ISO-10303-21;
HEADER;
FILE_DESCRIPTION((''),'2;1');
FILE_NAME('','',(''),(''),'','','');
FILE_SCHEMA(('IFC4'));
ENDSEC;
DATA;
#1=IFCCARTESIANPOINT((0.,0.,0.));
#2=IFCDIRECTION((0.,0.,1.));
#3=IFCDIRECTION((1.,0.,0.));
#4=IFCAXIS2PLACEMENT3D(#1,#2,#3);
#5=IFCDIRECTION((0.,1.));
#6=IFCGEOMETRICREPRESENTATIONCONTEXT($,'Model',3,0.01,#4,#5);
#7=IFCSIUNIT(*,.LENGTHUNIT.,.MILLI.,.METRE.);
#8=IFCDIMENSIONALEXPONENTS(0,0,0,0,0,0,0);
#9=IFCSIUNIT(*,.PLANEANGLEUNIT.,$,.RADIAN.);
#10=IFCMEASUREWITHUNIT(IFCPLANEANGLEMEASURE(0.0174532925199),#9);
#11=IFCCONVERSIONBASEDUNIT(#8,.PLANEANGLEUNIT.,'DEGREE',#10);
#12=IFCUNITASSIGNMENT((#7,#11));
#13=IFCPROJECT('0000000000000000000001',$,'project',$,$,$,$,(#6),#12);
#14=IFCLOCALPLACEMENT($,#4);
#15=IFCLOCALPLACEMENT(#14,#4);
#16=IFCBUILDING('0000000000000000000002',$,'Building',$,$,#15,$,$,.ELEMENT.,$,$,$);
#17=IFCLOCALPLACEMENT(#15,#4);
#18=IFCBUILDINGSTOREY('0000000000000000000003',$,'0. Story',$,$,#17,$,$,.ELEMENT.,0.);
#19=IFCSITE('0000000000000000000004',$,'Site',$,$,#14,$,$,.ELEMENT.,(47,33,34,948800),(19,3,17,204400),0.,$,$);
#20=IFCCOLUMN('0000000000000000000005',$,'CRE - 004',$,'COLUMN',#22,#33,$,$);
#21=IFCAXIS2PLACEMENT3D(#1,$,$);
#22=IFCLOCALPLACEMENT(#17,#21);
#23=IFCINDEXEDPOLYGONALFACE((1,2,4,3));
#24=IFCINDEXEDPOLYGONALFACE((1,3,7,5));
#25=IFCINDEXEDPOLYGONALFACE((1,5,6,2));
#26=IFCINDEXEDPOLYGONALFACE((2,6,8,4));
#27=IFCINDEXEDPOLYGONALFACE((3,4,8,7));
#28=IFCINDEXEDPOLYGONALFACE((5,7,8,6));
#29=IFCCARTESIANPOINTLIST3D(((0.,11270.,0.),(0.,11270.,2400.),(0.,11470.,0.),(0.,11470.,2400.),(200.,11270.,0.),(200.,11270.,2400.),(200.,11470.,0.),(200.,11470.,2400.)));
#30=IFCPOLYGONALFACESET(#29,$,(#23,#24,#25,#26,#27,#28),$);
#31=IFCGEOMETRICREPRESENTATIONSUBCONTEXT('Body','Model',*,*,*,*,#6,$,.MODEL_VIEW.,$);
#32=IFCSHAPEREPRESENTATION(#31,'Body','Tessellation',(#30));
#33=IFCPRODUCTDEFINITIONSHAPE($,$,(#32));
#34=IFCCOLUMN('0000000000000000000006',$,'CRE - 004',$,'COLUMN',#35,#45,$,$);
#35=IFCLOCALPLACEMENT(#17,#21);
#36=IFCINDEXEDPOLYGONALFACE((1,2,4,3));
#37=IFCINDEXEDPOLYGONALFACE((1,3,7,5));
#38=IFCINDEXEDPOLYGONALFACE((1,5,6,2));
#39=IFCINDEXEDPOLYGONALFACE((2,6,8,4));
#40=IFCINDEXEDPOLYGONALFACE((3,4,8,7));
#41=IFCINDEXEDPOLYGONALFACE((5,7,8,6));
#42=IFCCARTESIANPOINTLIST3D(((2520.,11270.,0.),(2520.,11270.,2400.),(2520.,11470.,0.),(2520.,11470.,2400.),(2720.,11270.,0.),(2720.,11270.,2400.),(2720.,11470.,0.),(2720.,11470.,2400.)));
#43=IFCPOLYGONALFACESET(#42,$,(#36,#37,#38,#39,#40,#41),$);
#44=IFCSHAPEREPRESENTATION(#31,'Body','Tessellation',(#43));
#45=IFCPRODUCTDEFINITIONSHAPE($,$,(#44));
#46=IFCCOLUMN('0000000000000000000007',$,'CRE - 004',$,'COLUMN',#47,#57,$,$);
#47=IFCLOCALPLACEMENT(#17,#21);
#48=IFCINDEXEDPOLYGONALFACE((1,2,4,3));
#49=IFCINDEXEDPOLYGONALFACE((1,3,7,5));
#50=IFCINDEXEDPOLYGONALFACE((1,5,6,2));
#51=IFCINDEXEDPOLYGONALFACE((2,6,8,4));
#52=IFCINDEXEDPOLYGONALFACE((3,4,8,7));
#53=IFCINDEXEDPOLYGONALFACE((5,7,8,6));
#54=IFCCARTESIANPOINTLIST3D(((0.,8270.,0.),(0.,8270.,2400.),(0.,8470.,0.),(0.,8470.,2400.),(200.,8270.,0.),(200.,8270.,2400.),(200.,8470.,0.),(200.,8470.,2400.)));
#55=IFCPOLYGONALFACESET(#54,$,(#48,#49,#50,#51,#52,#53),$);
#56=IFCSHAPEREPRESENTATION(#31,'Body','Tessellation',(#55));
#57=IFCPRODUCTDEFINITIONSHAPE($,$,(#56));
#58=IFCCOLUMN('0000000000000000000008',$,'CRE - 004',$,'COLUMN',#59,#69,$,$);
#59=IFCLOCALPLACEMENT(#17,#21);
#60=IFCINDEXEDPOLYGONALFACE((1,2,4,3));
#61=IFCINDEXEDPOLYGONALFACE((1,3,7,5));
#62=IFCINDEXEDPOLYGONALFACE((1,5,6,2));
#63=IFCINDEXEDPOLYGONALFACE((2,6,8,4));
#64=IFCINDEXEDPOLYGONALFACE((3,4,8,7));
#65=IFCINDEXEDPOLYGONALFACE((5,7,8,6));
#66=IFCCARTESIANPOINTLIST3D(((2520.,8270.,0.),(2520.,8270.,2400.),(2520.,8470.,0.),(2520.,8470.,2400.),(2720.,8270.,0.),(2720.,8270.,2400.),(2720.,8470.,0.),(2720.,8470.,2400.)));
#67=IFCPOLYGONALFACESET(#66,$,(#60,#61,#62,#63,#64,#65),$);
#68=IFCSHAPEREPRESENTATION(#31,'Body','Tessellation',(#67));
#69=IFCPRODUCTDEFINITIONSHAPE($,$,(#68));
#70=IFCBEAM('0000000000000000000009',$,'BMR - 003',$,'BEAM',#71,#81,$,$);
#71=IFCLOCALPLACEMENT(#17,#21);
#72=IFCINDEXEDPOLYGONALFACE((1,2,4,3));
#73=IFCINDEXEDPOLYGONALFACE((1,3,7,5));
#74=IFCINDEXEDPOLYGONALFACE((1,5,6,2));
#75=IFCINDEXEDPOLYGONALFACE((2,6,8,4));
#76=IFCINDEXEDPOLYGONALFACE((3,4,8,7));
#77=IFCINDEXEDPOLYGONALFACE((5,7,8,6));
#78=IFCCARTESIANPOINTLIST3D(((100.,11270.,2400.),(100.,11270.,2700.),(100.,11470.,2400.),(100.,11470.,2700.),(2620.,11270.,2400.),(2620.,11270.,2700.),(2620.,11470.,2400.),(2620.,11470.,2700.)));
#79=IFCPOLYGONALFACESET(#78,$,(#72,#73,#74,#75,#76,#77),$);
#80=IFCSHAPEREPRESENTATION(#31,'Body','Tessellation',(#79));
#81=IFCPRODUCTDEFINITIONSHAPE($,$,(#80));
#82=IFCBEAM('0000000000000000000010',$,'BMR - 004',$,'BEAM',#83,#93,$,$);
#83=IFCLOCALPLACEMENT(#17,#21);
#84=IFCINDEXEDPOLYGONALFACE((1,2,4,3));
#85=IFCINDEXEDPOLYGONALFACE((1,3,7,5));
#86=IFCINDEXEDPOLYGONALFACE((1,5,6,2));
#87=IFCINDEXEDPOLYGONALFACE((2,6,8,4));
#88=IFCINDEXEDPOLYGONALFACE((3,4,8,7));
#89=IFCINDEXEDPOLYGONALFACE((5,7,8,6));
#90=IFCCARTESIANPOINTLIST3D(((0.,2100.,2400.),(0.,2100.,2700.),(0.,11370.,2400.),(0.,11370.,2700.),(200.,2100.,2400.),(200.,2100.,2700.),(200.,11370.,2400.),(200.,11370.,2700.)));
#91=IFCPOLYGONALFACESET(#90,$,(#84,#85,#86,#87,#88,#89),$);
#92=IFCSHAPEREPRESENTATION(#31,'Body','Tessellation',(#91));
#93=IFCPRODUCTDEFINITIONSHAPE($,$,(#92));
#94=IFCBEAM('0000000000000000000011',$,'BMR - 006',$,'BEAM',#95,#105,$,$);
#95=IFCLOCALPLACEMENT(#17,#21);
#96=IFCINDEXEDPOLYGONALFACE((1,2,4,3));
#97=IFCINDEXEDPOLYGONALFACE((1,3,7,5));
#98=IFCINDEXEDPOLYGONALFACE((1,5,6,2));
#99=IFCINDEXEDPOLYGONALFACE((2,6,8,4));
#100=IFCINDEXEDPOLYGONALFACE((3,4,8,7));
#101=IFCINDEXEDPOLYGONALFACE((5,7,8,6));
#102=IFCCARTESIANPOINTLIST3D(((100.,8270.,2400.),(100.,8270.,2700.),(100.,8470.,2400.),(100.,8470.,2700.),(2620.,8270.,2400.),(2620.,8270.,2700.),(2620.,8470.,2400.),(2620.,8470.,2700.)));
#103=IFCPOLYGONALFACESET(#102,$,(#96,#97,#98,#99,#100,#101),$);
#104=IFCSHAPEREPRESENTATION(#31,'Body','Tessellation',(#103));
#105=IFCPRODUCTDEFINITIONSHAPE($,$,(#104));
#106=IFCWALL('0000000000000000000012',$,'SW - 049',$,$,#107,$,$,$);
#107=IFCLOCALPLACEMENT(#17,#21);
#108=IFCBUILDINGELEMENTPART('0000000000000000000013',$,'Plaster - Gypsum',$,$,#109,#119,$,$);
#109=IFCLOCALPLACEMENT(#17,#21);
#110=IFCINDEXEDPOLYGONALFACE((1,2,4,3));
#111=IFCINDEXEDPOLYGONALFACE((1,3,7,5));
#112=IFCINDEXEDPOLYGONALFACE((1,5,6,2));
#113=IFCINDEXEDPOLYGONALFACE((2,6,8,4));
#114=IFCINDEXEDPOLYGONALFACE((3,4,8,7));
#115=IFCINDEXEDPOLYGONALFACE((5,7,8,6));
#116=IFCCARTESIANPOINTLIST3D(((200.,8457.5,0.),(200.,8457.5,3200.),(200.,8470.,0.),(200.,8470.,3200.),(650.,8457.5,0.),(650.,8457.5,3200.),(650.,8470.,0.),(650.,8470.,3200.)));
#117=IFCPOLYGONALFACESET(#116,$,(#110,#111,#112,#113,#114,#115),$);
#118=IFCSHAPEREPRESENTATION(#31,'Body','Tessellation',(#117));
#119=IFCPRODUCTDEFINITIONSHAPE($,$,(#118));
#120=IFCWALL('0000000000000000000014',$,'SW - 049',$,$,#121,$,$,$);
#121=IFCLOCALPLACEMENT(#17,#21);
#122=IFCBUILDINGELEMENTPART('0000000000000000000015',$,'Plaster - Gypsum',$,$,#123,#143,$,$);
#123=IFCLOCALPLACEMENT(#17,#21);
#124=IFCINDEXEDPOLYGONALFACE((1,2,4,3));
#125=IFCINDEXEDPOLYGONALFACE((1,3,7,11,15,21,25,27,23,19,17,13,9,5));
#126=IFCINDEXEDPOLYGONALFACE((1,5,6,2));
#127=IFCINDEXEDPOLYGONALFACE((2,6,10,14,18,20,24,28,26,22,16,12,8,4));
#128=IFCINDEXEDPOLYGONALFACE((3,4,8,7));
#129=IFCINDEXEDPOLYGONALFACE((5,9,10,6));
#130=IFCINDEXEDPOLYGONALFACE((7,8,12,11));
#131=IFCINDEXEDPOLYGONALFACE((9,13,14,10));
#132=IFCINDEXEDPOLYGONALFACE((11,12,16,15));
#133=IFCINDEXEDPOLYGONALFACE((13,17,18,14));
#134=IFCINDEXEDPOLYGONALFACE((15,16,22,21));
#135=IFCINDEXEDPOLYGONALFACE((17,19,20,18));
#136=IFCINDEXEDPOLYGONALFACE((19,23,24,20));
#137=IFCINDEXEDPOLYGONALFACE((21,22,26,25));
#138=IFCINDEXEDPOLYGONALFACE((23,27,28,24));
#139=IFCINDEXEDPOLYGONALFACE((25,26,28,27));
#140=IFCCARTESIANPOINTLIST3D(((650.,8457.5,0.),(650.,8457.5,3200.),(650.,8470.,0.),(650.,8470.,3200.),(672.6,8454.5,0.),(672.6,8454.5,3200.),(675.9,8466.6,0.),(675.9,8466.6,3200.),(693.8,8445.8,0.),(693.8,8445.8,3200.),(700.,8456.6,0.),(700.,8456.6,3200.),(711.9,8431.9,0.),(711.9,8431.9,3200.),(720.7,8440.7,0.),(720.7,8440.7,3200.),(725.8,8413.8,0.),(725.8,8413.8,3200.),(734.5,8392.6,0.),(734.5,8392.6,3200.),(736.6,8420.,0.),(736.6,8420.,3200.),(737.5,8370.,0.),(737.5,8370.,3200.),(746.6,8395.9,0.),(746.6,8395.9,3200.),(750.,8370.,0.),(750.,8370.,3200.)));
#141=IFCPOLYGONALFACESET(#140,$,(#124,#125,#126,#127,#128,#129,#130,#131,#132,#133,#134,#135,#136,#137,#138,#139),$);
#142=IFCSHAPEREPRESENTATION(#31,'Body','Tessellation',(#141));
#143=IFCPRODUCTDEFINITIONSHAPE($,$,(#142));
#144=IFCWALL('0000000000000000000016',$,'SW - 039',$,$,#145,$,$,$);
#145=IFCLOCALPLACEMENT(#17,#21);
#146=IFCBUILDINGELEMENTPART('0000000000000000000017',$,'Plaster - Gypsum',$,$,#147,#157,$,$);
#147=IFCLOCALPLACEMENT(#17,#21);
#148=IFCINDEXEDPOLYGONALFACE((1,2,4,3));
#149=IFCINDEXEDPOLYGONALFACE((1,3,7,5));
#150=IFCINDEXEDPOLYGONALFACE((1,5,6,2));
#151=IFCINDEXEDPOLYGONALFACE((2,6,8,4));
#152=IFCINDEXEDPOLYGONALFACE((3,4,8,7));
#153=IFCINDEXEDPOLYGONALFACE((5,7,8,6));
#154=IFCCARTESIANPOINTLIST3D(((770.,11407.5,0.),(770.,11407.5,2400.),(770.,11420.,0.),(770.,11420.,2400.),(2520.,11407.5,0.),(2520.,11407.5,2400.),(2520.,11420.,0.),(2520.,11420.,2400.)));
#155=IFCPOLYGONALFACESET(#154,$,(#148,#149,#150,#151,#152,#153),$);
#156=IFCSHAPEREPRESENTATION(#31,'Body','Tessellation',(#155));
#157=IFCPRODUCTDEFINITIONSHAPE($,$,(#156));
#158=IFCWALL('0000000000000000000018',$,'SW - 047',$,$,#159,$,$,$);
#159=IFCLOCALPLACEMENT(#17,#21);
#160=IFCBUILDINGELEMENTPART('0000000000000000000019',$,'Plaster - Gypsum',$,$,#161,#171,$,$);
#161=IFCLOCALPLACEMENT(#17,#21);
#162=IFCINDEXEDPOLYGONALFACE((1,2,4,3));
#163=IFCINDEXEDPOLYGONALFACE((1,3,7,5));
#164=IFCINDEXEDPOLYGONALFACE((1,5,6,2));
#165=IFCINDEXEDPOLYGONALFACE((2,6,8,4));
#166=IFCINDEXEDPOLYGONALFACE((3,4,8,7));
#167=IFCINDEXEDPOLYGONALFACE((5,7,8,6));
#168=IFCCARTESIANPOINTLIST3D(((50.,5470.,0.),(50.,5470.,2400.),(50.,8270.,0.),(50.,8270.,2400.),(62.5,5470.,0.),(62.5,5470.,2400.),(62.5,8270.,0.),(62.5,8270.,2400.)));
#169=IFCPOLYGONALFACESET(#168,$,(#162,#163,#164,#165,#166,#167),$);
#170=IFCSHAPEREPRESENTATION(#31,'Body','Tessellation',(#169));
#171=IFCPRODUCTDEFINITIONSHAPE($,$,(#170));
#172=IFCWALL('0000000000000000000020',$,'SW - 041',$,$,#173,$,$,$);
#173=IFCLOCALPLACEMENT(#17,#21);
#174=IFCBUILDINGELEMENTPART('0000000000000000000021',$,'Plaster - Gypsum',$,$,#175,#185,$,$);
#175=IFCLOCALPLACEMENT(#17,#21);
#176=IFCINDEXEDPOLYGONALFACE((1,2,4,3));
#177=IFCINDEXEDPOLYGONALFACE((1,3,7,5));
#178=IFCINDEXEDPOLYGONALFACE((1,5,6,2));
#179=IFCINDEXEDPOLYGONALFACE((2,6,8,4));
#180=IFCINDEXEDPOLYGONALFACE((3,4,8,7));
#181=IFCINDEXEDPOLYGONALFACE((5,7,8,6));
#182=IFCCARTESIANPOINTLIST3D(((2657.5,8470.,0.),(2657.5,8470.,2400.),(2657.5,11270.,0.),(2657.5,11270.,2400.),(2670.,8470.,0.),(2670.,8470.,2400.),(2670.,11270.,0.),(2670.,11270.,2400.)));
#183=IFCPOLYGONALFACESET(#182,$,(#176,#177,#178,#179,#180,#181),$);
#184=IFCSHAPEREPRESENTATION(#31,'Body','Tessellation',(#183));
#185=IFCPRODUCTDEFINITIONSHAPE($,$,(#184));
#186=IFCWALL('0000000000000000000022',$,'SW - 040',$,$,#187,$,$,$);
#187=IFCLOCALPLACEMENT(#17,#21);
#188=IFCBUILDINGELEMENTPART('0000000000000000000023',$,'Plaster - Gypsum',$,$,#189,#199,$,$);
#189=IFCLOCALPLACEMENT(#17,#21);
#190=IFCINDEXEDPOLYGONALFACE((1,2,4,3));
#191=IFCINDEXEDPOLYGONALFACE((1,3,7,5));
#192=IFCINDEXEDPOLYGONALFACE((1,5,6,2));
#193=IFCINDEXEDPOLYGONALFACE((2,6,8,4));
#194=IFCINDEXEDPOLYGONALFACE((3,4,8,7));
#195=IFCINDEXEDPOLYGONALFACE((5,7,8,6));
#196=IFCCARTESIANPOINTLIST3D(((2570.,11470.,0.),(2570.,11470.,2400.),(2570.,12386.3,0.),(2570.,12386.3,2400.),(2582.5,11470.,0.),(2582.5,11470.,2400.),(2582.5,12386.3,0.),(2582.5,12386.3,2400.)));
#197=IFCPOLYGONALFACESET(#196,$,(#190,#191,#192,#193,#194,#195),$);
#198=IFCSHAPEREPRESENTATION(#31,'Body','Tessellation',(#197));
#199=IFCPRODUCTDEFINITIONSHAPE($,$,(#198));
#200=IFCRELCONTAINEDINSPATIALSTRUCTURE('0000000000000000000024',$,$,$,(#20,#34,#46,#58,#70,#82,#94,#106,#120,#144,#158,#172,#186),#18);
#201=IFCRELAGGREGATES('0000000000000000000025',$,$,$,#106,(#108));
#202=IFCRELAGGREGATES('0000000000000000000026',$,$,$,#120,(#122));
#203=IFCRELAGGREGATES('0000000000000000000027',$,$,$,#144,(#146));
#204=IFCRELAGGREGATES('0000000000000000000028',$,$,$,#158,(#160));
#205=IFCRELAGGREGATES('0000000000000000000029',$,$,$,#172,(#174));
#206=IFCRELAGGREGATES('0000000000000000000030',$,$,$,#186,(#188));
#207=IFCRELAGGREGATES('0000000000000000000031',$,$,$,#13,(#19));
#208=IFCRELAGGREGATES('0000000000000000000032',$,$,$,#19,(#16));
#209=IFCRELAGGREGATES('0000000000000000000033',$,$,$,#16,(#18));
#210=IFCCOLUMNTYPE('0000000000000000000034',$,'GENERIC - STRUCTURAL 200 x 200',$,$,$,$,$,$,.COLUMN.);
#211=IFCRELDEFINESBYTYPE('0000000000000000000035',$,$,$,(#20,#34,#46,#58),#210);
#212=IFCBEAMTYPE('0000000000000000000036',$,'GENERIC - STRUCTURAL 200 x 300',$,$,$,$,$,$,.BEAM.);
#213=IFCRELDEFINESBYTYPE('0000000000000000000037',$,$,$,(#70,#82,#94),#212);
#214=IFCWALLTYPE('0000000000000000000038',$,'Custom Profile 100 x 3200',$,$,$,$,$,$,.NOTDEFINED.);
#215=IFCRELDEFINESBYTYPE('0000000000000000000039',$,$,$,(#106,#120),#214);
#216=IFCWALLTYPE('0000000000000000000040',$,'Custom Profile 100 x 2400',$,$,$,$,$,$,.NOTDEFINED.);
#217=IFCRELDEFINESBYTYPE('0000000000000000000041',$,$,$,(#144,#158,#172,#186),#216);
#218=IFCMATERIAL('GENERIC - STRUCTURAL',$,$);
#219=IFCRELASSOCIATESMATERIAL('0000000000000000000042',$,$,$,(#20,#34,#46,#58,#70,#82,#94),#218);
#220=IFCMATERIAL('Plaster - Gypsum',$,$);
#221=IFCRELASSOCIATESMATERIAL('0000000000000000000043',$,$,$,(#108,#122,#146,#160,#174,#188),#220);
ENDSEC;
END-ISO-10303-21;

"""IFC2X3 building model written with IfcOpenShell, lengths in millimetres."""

from ifc_helpers import new_model, entity, si_unit, converted_unit, direction, frame, frame_2d, origin_with_axes, origin_2d_with_axis, place, context, subcontext, project, spatial, polyline, rectangle, outline, extrude, material, type_object, element, aggregate, save


model = new_model("IFC2X3")

# Units and contexts
model_context = context("Model", 3, precision=0.01, world=origin_with_axes(), true_north=direction((0.0, 1.0)))
body_context = subcontext(model_context, "Body", "Model", "MODEL_VIEW")
ifc_project = project(units=[si_unit("LENGTHUNIT", "METRE", prefix="MILLI"), converted_unit("PLANEANGLEUNIT", "DEGREE", entity("IfcPlaneAngleMeasure", 0.0174532925199), si_unit("PLANEANGLEUNIT", "RADIAN"), dimensions=[0, 0, 0, 0, 0, 0, 0])], contexts=[model_context])

# Site, building, storey
site_placement = place(None, origin_with_axes())
site = spatial("IfcSite", under=ifc_project, at=site_placement, Name="Site", CompositionType="ELEMENT", RefLatitude=(47, 33, 34, 948800), RefLongitude=(19, 3, 17, 204400), RefElevation=0.0)
building_placement = place(site_placement, origin_with_axes())
building = spatial("IfcBuilding", under=site, at=building_placement, Name="Building", CompositionType="ELEMENT")
storey_placement = place(building_placement, origin_with_axes())
storey = spatial("IfcBuildingStorey", under=building, at=storey_placement, Name="0. Story", CompositionType="ELEMENT", Elevation=0.0)

# Columns
ifc_material_1 = material(Name="GENERIC - STRUCTURAL")
column_type = type_object("IfcColumnType", Name="GENERIC - STRUCTURAL 200 x 200", PredefinedType="COLUMN")
for number, where, z_axis, x_axis, name in (
    (1, (100.0, 11370.0, 0.0), (0.0, 0.0, 1.0), (1.0, 0.0, 0.0), "CRE - 004"),
    (2, (2620.0, 11370.0, 0.0), (0.0, 0.0, 1.0), (1.0, 0.0, 0.0), "CRE - 004"),
    (3, (100.0, 8370.0, 0.0), (0.0, 0.0, 1.0), (1.0, 0.0, 0.0), "CRE - 004"),
    (4, (2620.0, 8370.0, 0.0), (0.0, 0.0, 1.0), (1.0, 0.0, 0.0), "CRE - 004"),
):
    element("IfcColumn", number, at=place(storey_placement, frame(where, z_axis=z_axis, x_axis=x_axis)), inside=storey, type_object=column_type, material=ifc_material_1, Name=name, ObjectType="COLUMN", context=body_context, shape_type="SweptSolid", body=[
        extrude(rectangle(XDim=200.0, YDim=200.0, at=origin_2d_with_axis()), origin_with_axes(), (0.0, 0.0, 1.0), 2400.0),
    ])

# Beams
beam_type = type_object("IfcBeamType", Name="GENERIC - STRUCTURAL 200 x 300", PredefinedType="BEAM")
beam_1_placement = place(storey_placement, frame((2620.0, 11370.0, 2700.0), z_axis=(0.0, 0.0, 1.0), x_axis=(0.0, 1.0, 0.0)))
element("IfcBeam", 5, at=beam_1_placement, inside=storey, type_object=beam_type, material=ifc_material_1, Name="BMR - 003", ObjectType="BEAM", context=body_context, shape_type="SweptSolid", body=[
    extrude(rectangle(XDim=300.0, YDim=200.0, at=frame_2d((-150.0, 0.0), x_axis=(1.0, 0.0))), frame((0.0, 0.0, 0.0), z_axis=(0.0, 1.0, 0.0), x_axis=(0.0, 0.0, 1.0)), (0.0, 0.0, 1.0), 2520.0),
])
beam_2_placement = place(storey_placement, frame((100.0, 11370.0, 2700.0), z_axis=(0.0, 0.0, 1.0), x_axis=(-1.0, 0.0, 0.0)))
element("IfcBeam", 6, at=beam_2_placement, inside=storey, type_object=beam_type, material=ifc_material_1, Name="BMR - 004", ObjectType="BEAM", context=body_context, shape_type="SweptSolid", body=[
    extrude(rectangle(XDim=300.0, YDim=200.0, at=frame_2d((-150.0, 0.0), x_axis=(1.0, 0.0))), frame((0.0, 0.0, 0.0), z_axis=(0.0, 1.0, 0.0), x_axis=(0.0, 0.0, 1.0)), (0.0, 0.0, 1.0), 9270.0),
])
beam_3_placement = place(storey_placement, frame((100.0, 8370.0, 2700.0), z_axis=(0.0, 0.0, 1.0), x_axis=(0.0, -1.0, 0.0)))
element("IfcBeam", 7, at=beam_3_placement, inside=storey, type_object=beam_type, material=ifc_material_1, Name="BMR - 006", ObjectType="BEAM", context=body_context, shape_type="SweptSolid", body=[
    extrude(rectangle(XDim=300.0, YDim=200.0, at=frame_2d((-150.0, 0.0), x_axis=(1.0, 0.0))), frame((0.0, 0.0, 0.0), z_axis=(0.0, 1.0, 0.0), x_axis=(0.0, 0.0, 1.0)), (0.0, 0.0, 1.0), 2520.0),
])

# Walls, building element parts
wall_type_1 = type_object("IfcWallType", Name="Custom Profile 100 x 3200", PredefinedType="NOTDEFINED")
wall_1_placement = place(storey_placement, frame((200.0, 8470.0, 0.0), z_axis=(0.0, 0.0, 1.0), x_axis=(1.0, 0.0, 0.0)))
wall_1 = element("IfcWall", 8, at=wall_1_placement, inside=storey, type_object=wall_type_1, Name="SW - 049")
ifc_material_2 = material(Name="Plaster - Gypsum")
building_element_part_1_placement = place(wall_1_placement, origin_with_axes())
building_element_part_1 = element("IfcBuildingElementPart", 9, at=building_element_part_1_placement, material=ifc_material_2, Name="Plaster - Gypsum", context=body_context, shape_type="SweptSolid", body=[
    extrude(outline(polyline([(-12.5, 3200.0), (-12.5, 0.0), (0.0, 0.0), (0.0, 3200.0), (-12.5, 3200.0)])), frame((0.0, 0.0, 0.0), z_axis=(1.0, 0.0, 0.0), x_axis=(0.0, 1.0, 0.0)), (0.0, 0.0, 1.0), 450.0),
])
aggregate(wall_1, [building_element_part_1])
wall_2_placement = place(storey_placement, frame((750.0, 8370.0, 0.0), z_axis=(0.0, 0.0, 1.0), x_axis=(0.0, 1.0, 0.0)))
wall_2 = element("IfcWall", 10, at=wall_2_placement, inside=storey, type_object=wall_type_1, Name="SW - 049")
building_element_part_2_placement = place(wall_2_placement, origin_with_axes())
cartesian_point_1 = entity("IfcCartesianPoint", [-12.5, 3200.0])
building_element_part_2 = element("IfcBuildingElementPart", 11, at=building_element_part_2_placement, material=ifc_material_2, Name="Plaster - Gypsum", context=body_context, shape_type="SweptSolid", body=[
    entity("IfcRevolvedAreaSolid", entity("IfcArbitraryClosedProfileDef", "AREA", None, entity("IfcPolyline", [cartesian_point_1, entity("IfcCartesianPoint", [-12.5, 0.0]), entity("IfcCartesianPoint", [0.0, 0.0]), entity("IfcCartesianPoint", [0.0, 3200.0]), cartesian_point_1])), entity("IfcAxis2Placement3D", entity("IfcCartesianPoint", [0.0, 0.0, 0.0]), entity("IfcDirection", [-1.0, 0.0, 0.0]), entity("IfcDirection", [0.0, -1.0, 0.0])), entity("IfcAxis1Placement", entity("IfcCartesianPoint", [-100.0, 0.0, 0.0]), entity("IfcDirection", [0.0, 1.0, 0.0])), 90.0),
])
aggregate(wall_2, [building_element_part_2])

# Shared definitions
wall_type_2 = type_object("IfcWallType", Name="Custom Profile 100 x 2400", PredefinedType="NOTDEFINED")

# Walls, building element parts
wall_3_placement = place(storey_placement, frame((2520.0, 11420.0, 0.0), z_axis=(0.0, 0.0, 1.0), x_axis=(-1.0, 0.0, 0.0)))
wall_3 = element("IfcWall", 12, at=wall_3_placement, inside=storey, type_object=wall_type_2, Name="SW - 039")
building_element_part_3_placement = place(wall_3_placement, origin_with_axes())
building_element_part_3 = element("IfcBuildingElementPart", 13, at=building_element_part_3_placement, material=ifc_material_2, Name="Plaster - Gypsum", context=body_context, shape_type="SweptSolid", body=[
    extrude(outline(polyline([(-12.5, 2400.0), (-12.5, 0.0), (0.0, 0.0), (0.0, 2400.0), (-12.5, 2400.0)])), frame((0.0, 0.0, 0.0), z_axis=(-1.0, 0.0, 0.0), x_axis=(0.0, -1.0, 0.0)), (0.0, 0.0, -1.0), 1750.0),
])
aggregate(wall_3, [building_element_part_3])
wall_4_placement = place(storey_placement, frame((50.0, 8270.0, 0.0), z_axis=(0.0, 0.0, 1.0), x_axis=(0.0, -1.0, 0.0)))
wall_4 = element("IfcWall", 14, at=wall_4_placement, inside=storey, type_object=wall_type_2, Name="SW - 047")
building_element_part_4_placement = place(wall_4_placement, origin_with_axes())
building_element_part_4 = element("IfcBuildingElementPart", 15, at=building_element_part_4_placement, material=ifc_material_2, Name="Plaster - Gypsum", context=body_context, shape_type="SweptSolid", body=[
    extrude(outline(polyline([(-12.5, 2400.0), (-12.5, 0.0), (0.0, 0.0), (0.0, 2400.0), (-12.5, 2400.0)])), frame((0.0, 0.0, 0.0), z_axis=(-1.0, 0.0, 0.0), x_axis=(0.0, -1.0, 0.0)), (0.0, 0.0, -1.0), 2800.0),
])
aggregate(wall_4, [building_element_part_4])
wall_5_placement = place(storey_placement, frame((2670.0, 8470.0, 0.0), z_axis=(0.0, 0.0, 1.0), x_axis=(0.0, 1.0, 0.0)))
wall_5 = element("IfcWall", 16, at=wall_5_placement, inside=storey, type_object=wall_type_2, Name="SW - 041")
building_element_part_5_placement = place(wall_5_placement, origin_with_axes())
building_element_part_5 = element("IfcBuildingElementPart", 17, at=building_element_part_5_placement, material=ifc_material_2, Name="Plaster - Gypsum", context=body_context, shape_type="SweptSolid", body=[
    extrude(outline(polyline([(-12.5, 2400.0), (-12.5, 0.0), (0.0, 0.0), (0.0, 2400.0), (-12.5, 2400.0)])), frame((0.0, 0.0, 0.0), z_axis=(-1.0, 0.0, 0.0), x_axis=(0.0, -1.0, 0.0)), (0.0, 0.0, -1.0), 2800.0),
])
aggregate(wall_5, [building_element_part_5])
wall_6_placement = place(storey_placement, frame((2570.0, 11470.0, 0.0), z_axis=(0.0, 0.0, 1.0), x_axis=(0.0, 1.0, 0.0)))
wall_6 = element("IfcWall", 18, at=wall_6_placement, inside=storey, type_object=wall_type_2, Name="SW - 040")
building_element_part_6_placement = place(wall_6_placement, origin_with_axes())
building_element_part_6 = element("IfcBuildingElementPart", 19, at=building_element_part_6_placement, material=ifc_material_2, Name="Plaster - Gypsum", context=body_context, shape_type="SweptSolid", body=[
    extrude(outline(polyline([(-12.5, 2400.0), (-12.5, 0.0), (0.0, 0.0), (0.0, 2400.0), (-12.5, 2400.0)])), frame((0.0, 0.0, 0.0), z_axis=(1.0, 0.0, 0.0), x_axis=(0.0, 1.0, 0.0)), (0.0, 0.0, 1.0), 916.3),
])
aggregate(wall_6, [building_element_part_6])

save(model, "model.ifc")
